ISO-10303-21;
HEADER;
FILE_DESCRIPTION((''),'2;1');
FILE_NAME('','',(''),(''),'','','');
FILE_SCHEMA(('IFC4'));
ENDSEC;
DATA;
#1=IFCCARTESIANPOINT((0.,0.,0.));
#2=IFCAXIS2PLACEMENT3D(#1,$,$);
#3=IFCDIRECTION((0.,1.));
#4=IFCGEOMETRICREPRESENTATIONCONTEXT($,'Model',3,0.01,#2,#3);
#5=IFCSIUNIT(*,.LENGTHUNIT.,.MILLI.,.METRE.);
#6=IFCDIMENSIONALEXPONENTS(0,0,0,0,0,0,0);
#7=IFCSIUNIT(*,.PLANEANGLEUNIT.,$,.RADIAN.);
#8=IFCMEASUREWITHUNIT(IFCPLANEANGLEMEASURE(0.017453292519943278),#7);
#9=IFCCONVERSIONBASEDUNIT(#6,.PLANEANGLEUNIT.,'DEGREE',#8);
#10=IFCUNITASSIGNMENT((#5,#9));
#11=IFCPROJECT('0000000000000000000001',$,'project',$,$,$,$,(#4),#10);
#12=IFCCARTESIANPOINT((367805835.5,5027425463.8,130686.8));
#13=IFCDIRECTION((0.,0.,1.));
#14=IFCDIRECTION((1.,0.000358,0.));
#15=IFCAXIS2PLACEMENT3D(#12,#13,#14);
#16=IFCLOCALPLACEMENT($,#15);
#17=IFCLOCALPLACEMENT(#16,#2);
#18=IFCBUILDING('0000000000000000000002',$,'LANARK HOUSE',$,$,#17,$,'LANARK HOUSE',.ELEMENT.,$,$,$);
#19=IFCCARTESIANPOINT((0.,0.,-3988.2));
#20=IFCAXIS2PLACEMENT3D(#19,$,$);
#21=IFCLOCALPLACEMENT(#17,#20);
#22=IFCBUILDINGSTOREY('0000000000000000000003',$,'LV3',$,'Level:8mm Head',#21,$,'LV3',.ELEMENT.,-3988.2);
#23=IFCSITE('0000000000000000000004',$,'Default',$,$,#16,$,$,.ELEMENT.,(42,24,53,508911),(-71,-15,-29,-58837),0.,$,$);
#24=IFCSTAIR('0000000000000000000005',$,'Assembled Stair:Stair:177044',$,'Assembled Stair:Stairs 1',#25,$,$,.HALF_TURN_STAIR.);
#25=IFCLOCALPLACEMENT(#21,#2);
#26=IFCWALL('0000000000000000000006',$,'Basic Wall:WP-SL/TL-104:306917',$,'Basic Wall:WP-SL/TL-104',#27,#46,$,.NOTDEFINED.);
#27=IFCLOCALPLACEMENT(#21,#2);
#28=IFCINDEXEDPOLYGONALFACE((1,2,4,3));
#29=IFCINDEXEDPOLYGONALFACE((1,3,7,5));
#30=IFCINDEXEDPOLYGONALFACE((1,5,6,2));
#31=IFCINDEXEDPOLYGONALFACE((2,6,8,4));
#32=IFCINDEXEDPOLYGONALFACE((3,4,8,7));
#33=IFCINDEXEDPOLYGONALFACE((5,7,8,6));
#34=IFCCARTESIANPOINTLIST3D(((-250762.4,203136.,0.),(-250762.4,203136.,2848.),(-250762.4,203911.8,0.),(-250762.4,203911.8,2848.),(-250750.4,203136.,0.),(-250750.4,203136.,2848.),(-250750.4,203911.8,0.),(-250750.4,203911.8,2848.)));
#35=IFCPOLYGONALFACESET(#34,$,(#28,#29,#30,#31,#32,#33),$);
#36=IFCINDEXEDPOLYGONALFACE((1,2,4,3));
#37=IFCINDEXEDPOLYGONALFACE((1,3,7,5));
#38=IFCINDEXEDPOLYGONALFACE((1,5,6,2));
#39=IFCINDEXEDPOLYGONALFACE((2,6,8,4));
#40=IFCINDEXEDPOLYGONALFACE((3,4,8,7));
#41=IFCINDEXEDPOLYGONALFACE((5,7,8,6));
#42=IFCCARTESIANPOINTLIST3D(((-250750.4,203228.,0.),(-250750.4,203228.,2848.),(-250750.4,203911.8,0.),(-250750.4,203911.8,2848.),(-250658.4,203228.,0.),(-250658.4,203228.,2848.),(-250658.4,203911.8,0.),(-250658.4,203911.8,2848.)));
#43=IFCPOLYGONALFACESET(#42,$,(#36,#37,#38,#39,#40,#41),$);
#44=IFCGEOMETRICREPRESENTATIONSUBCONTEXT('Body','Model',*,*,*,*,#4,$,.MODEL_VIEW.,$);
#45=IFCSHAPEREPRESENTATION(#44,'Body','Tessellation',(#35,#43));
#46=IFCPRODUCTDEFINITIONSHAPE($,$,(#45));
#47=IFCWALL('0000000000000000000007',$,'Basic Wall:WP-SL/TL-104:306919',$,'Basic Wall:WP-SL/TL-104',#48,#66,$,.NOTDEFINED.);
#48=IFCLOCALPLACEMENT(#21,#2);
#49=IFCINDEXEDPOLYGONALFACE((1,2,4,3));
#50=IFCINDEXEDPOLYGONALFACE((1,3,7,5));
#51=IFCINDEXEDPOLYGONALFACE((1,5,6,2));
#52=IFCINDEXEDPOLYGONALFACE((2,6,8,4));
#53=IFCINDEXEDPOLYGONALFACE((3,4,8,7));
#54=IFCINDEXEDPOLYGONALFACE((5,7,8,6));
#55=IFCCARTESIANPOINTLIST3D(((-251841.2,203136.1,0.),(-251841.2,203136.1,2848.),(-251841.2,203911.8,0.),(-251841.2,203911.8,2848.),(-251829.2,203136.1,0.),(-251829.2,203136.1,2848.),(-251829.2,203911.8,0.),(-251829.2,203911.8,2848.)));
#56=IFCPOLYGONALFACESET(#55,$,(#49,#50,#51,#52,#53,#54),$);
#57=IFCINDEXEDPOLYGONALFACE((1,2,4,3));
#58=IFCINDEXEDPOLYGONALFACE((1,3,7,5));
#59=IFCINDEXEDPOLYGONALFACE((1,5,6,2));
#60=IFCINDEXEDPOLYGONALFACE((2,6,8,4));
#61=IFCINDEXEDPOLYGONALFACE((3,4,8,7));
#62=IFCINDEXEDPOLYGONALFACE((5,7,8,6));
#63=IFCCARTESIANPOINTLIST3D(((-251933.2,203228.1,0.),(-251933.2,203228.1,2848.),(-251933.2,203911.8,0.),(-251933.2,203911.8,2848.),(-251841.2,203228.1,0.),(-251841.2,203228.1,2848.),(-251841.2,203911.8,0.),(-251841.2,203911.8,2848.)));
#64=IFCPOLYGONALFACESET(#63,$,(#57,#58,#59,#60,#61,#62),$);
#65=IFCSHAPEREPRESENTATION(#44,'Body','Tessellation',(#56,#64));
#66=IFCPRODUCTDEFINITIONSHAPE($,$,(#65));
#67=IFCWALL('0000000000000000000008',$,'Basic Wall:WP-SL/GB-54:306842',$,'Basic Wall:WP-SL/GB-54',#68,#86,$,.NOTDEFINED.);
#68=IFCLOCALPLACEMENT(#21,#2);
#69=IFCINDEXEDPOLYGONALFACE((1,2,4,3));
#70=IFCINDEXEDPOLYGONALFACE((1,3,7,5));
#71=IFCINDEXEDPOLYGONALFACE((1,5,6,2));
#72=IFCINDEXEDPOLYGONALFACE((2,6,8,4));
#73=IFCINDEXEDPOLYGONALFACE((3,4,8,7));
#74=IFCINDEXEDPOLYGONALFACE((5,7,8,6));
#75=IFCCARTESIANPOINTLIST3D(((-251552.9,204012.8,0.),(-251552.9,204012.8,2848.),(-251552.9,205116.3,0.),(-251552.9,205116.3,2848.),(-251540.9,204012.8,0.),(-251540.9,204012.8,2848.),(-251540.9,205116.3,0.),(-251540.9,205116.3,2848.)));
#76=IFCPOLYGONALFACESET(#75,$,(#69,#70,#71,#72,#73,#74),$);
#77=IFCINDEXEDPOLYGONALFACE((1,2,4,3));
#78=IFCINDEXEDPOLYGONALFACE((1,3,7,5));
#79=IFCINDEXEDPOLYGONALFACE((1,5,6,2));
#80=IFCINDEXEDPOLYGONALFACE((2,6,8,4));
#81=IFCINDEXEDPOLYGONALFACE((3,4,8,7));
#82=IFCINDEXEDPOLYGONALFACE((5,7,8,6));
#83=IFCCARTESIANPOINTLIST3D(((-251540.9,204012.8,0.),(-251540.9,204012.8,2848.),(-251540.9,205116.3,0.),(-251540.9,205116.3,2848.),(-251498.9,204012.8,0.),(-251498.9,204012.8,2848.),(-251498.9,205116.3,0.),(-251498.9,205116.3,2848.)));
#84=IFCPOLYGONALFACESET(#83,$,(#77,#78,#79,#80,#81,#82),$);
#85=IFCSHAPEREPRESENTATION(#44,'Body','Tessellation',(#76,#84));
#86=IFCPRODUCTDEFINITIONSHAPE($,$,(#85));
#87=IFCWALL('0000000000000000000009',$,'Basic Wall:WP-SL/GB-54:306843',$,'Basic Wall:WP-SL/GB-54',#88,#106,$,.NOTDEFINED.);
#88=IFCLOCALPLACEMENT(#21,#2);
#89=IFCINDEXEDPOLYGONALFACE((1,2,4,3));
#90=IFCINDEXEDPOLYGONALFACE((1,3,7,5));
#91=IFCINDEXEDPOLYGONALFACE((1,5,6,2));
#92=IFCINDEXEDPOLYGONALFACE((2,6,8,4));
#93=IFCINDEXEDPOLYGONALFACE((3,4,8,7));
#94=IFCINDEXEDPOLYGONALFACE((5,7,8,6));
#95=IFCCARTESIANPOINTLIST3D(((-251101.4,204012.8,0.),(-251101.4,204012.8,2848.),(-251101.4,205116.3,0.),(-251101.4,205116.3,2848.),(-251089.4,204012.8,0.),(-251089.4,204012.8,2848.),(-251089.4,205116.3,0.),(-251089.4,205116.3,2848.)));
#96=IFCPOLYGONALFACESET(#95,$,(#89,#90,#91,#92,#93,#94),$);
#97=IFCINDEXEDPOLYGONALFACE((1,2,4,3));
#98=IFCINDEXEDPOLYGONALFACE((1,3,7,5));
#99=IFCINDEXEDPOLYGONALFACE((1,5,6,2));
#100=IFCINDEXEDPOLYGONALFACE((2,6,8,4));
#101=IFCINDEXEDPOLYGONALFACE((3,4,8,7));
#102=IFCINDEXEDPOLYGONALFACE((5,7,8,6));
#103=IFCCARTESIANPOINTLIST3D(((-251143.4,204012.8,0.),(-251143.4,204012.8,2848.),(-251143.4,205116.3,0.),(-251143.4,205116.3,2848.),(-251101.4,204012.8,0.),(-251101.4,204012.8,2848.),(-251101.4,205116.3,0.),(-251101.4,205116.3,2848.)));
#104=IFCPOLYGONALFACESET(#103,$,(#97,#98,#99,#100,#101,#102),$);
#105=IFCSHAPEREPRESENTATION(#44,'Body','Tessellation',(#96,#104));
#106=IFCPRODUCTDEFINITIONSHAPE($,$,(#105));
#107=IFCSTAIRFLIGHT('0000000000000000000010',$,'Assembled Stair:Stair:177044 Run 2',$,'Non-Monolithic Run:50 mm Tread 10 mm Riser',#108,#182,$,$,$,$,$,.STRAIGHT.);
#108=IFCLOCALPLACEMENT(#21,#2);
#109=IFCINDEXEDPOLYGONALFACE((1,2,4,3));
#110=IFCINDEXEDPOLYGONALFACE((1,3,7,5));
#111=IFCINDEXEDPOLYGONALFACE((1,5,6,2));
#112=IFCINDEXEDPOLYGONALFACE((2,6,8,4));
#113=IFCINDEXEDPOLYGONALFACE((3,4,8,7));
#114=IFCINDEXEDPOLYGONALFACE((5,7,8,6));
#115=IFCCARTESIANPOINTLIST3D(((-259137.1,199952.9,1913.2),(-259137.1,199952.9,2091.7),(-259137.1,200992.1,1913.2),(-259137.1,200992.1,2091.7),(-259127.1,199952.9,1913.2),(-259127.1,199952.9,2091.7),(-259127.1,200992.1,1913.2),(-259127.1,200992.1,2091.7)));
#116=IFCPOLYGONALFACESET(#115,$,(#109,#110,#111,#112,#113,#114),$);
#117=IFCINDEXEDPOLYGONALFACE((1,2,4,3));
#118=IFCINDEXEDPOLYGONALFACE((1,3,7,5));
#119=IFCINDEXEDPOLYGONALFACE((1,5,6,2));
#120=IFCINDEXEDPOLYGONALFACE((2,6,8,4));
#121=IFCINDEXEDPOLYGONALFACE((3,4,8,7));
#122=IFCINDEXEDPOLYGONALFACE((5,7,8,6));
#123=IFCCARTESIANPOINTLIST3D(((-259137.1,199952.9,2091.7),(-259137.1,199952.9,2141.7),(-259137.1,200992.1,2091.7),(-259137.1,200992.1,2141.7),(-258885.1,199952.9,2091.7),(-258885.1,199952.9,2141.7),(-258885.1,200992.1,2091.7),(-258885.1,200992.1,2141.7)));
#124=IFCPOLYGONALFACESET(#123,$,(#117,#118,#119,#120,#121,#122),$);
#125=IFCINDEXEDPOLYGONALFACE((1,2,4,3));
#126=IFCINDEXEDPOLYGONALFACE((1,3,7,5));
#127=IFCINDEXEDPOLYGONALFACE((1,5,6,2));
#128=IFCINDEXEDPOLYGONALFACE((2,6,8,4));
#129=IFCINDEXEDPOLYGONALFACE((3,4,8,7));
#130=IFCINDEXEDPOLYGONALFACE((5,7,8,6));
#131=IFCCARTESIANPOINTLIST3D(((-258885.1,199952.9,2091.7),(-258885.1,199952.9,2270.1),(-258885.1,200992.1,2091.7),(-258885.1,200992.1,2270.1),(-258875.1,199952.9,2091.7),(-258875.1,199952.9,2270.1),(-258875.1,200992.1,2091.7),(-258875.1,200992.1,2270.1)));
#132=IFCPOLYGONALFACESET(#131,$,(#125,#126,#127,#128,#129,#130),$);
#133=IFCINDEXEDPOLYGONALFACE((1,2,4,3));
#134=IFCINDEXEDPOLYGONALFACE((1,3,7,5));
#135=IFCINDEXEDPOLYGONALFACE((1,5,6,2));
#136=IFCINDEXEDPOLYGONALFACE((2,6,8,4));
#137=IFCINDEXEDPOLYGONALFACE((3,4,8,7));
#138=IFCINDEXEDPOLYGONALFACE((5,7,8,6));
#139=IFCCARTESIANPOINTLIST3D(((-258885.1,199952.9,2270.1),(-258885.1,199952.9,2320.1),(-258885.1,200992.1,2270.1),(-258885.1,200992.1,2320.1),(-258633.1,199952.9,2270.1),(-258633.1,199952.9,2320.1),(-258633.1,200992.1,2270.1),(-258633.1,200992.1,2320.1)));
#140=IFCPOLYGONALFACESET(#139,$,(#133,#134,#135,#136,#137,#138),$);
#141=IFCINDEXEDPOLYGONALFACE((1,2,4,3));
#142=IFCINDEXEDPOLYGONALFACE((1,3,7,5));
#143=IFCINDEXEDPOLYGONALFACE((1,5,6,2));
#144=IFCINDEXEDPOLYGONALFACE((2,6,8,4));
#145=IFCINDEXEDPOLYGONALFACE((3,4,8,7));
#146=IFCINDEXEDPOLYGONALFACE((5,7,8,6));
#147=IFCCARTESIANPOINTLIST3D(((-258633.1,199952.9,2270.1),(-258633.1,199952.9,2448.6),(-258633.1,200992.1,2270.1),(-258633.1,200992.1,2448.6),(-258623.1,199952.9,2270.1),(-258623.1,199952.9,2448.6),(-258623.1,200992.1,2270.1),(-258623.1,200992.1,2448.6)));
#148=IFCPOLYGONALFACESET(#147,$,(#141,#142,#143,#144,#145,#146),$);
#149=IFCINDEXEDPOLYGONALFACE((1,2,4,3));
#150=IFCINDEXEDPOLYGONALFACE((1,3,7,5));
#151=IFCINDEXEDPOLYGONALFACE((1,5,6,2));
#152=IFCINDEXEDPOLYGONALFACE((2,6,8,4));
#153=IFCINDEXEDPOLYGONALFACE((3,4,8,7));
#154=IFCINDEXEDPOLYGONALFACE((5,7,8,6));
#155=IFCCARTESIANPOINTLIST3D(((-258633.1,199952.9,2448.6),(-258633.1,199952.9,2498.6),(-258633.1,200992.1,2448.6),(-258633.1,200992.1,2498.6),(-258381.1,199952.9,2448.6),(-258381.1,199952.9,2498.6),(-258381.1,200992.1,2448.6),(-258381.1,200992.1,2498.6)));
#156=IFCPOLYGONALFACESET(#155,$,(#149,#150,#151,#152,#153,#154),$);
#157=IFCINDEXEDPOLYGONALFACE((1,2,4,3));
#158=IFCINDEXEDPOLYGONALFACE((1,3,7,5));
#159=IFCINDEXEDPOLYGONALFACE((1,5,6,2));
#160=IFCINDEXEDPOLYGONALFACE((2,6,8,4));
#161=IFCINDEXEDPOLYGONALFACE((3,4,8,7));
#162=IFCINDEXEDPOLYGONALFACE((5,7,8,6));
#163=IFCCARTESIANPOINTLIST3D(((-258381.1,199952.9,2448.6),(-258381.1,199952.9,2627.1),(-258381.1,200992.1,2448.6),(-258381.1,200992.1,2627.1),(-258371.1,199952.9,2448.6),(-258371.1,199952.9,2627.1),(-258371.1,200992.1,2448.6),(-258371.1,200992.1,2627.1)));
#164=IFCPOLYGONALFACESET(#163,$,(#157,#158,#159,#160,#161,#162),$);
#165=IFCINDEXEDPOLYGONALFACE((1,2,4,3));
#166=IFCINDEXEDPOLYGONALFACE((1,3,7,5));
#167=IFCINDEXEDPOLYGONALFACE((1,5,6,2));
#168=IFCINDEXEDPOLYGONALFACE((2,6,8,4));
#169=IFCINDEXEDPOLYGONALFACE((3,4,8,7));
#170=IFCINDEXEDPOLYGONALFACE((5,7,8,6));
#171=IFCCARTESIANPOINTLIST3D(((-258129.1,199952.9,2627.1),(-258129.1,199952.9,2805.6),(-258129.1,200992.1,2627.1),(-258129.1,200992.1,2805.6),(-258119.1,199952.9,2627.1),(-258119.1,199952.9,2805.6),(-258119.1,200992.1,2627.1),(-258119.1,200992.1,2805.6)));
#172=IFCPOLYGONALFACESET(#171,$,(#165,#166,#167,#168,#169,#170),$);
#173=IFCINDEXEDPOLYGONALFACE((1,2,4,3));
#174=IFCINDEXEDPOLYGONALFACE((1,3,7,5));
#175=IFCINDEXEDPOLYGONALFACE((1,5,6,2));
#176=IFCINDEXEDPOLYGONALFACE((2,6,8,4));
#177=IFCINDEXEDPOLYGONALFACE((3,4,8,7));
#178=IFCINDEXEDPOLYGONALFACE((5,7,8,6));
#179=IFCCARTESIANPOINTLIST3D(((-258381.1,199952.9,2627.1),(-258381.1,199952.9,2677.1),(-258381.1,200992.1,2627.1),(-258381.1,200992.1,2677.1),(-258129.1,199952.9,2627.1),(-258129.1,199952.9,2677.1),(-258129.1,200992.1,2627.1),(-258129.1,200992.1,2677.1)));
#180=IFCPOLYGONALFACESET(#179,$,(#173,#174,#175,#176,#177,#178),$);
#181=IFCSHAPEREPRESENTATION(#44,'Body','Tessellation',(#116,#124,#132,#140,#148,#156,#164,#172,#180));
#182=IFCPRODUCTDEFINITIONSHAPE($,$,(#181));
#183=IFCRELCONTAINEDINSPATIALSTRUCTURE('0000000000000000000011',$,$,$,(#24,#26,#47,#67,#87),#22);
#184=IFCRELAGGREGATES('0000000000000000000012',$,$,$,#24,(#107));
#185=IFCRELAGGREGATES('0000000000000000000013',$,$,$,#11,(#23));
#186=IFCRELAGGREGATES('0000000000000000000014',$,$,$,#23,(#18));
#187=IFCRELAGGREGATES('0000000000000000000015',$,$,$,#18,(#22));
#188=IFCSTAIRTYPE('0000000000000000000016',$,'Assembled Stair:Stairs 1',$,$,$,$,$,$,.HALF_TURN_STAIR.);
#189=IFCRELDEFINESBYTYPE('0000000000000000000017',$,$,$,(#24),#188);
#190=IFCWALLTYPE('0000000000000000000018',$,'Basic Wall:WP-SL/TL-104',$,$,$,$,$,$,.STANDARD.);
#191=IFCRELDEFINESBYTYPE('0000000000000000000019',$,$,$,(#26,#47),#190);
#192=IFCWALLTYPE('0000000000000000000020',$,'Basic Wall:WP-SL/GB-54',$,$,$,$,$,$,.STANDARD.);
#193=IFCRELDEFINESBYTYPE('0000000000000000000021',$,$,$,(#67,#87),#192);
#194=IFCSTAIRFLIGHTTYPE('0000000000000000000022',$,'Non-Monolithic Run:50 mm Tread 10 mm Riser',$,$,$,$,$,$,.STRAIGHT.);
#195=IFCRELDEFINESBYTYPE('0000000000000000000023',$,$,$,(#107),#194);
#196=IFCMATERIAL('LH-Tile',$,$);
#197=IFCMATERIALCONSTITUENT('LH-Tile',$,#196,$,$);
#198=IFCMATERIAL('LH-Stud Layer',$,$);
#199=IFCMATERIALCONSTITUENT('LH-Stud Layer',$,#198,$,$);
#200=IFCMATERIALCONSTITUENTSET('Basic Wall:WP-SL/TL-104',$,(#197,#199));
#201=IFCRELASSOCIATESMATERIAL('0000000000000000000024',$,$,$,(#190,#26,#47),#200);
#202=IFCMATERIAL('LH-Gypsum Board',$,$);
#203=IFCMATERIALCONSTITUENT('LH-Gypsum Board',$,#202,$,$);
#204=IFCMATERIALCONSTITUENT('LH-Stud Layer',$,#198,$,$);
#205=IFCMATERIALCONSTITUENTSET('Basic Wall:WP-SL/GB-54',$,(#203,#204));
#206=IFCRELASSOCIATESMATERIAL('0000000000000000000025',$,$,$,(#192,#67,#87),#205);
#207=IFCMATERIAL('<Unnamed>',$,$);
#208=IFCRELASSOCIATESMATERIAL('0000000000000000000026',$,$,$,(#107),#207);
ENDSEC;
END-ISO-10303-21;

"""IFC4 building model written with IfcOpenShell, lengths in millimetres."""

from ifc_helpers import new_model, entity, si_unit, converted_unit, direction, frame, origin, place, context, subcontext, project, spatial, indexed_curve, outline, extrude, material, constituent, constituent_set, type_object, element, aggregate, save


model = new_model("IFC4")

# Units and contexts
model_context = context("Model", 3, precision=0.01, world=origin(), true_north=direction((0.0, 1.0)))
body_context = subcontext(model_context, "Body", "Model", "MODEL_VIEW")
ifc_project = project(units=[si_unit("LENGTHUNIT", "METRE", prefix="MILLI"), converted_unit("PLANEANGLEUNIT", "DEGREE", entity("IfcPlaneAngleMeasure", 0.017453292519943278), si_unit("PLANEANGLEUNIT", "RADIAN"), dimensions=[0, 0, 0, 0, 0, 0, 0])], contexts=[model_context])

# Site, building, storey
site_placement = place(None, frame((367805835.5, 5027425463.8, 130686.8), z_axis=(0.0, 0.0, 1.0), x_axis=(1.0, 0.000358, 0.0)))
site = spatial("IfcSite", under=ifc_project, at=site_placement, Name="Default", CompositionType="ELEMENT", RefLatitude=(42, 24, 53, 508911), RefLongitude=(-71, -15, -29, -58837), RefElevation=0.0)
building_placement = place(site_placement, origin())
building = spatial("IfcBuilding", under=site, at=building_placement, Name="LANARK HOUSE", LongName="LANARK HOUSE", CompositionType="ELEMENT")
storey_placement = place(building_placement, frame((0.0, 0.0, -3988.2)))
storey = spatial("IfcBuildingStorey", under=building, at=storey_placement, Name="LV3", ObjectType="Level:8mm Head", LongName="LV3", CompositionType="ELEMENT", Elevation=-3988.2)

# Stair
stair_type = type_object("IfcStairType", Name="Assembled Stair:Stairs 1", PredefinedType="HALF_TURN_STAIR")
stair_placement = place(storey_placement, origin())
stair = element("IfcStair", 1, at=stair_placement, inside=storey, type_object=stair_type, Name="Assembled Stair:Stair:177044", ObjectType="Assembled Stair:Stairs 1", PredefinedType="HALF_TURN_STAIR")
ifc_material_1 = material(Name="<Unnamed>")

# Walls
ifc_material_2 = material(Name="LH-Tile")
ifc_constituent_1 = constituent(ifc_material_2, Name="LH-Tile")
ifc_material_3 = material(Name="LH-Stud Layer")
ifc_constituent_2 = constituent(ifc_material_3, Name="LH-Stud Layer")
ifc_constituent_set_1 = constituent_set(constituents=[ifc_constituent_1, ifc_constituent_2], Name="Basic Wall:WP-SL/TL-104")
wall_type_1 = type_object("IfcWallType", Name="Basic Wall:WP-SL/TL-104", PredefinedType="STANDARD", material=ifc_constituent_set_1)
wall_1_placement = place(storey_placement, frame((-250710.4, 203228.0, 0.0), z_axis=(0.0, 0.0, 1.0), x_axis=(0.0, 1.0, 0.0)))
element("IfcWall", 2, at=wall_1_placement, inside=storey, type_object=wall_type_1, material=ifc_constituent_set_1, Name="Basic Wall:WP-SL/TL-104:306917", ObjectType="Basic Wall:WP-SL/TL-104", PredefinedType="NOTDEFINED", context=body_context, shape_type="SweptSolid", body=[
    extrude(outline(indexed_curve([(-6.0, -387.9), (6.0, -387.9), (6.0, 387.9), (-6.0, 387.9), (-6.0, -387.9)], self_intersect=False)), frame((295.9, 46.0, 0.0), z_axis=(0.0, 0.0, 1.0), x_axis=(0.0, -1.0, 0.0)), (0.0, 0.0, 1.0), 2848.0),
    extrude(outline(indexed_curve([(-46.0, -341.9), (46.0, -341.9), (46.0, 341.9), (-46.0, 341.9), (-46.0, -341.9)], self_intersect=False)), frame((341.9, -6.0, 0.0), z_axis=(0.0, 0.0, 1.0), x_axis=(0.0, 1.0, 0.0)), (0.0, 0.0, 1.0), 2848.0),
])
wall_2_placement = place(storey_placement, frame((-251881.2, 203911.8, 0.0), z_axis=(0.0, 0.0, 1.0), x_axis=(0.0, -1.0, 0.0)))
element("IfcWall", 3, at=wall_2_placement, inside=storey, type_object=wall_type_1, material=ifc_constituent_set_1, Name="Basic Wall:WP-SL/TL-104:306919", ObjectType="Basic Wall:WP-SL/TL-104", PredefinedType="NOTDEFINED", context=body_context, shape_type="SweptSolid", body=[
    extrude(outline(indexed_curve([(-6.0, -387.8), (6.0, -387.8), (6.0, 387.8), (-6.0, 387.8), (-6.0, -387.8)], self_intersect=False)), frame((387.8, 46.0, 0.0), z_axis=(0.0, 0.0, 1.0), x_axis=(0.0, -1.0, 0.0)), (0.0, 0.0, 1.0), 2848.0),
    extrude(outline(indexed_curve([(-46.0, -341.8), (46.0, -341.8), (46.0, 341.8), (-46.0, 341.8), (-46.0, -341.8)], self_intersect=False)), frame((341.8, -6.0, 0.0), z_axis=(0.0, 0.0, 1.0), x_axis=(0.0, 1.0, 0.0)), (0.0, 0.0, 1.0), 2848.0),
])
ifc_material_4 = material(Name="LH-Gypsum Board")
ifc_constituent_3 = constituent(ifc_material_4, Name="LH-Gypsum Board")
ifc_constituent_4 = constituent(ifc_material_3, Name="LH-Stud Layer")
ifc_constituent_set_2 = constituent_set(constituents=[ifc_constituent_3, ifc_constituent_4], Name="Basic Wall:WP-SL/GB-54")
wall_type_2 = type_object("IfcWallType", Name="Basic Wall:WP-SL/GB-54", PredefinedType="STANDARD", material=ifc_constituent_set_2)
wall_3_placement = place(storey_placement, frame((-251525.9, 204012.8, 0.0), z_axis=(0.0, 0.0, 1.0), x_axis=(0.0, 1.0, 0.0)))
element("IfcWall", 4, at=wall_3_placement, inside=storey, type_object=wall_type_2, material=ifc_constituent_set_2, Name="Basic Wall:WP-SL/GB-54:306842", ObjectType="Basic Wall:WP-SL/GB-54", PredefinedType="NOTDEFINED", context=body_context, shape_type="SweptSolid", body=[
    extrude(outline(indexed_curve([(-6.0, -551.8), (6.0, -551.8), (6.0, 551.8), (-6.0, 551.8), (-6.0, -551.8)], self_intersect=False)), frame((551.8, 21.0, 0.0), z_axis=(0.0, 0.0, 1.0), x_axis=(0.0, -1.0, 0.0)), (0.0, 0.0, 1.0), 2848.0),
    extrude(outline(indexed_curve([(-21.0, -551.8), (21.0, -551.8), (21.0, 551.8), (-21.0, 551.8), (-21.0, -551.8)], self_intersect=False)), frame((551.8, -6.0, 0.0), z_axis=(0.0, 0.0, 1.0), x_axis=(0.0, 1.0, 0.0)), (0.0, 0.0, 1.0), 2848.0),
])
wall_4_placement = place(storey_placement, frame((-251116.4, 205116.3, 0.0), z_axis=(0.0, 0.0, 1.0), x_axis=(0.0, -1.0, 0.0)))
element("IfcWall", 5, at=wall_4_placement, inside=storey, type_object=wall_type_2, material=ifc_constituent_set_2, Name="Basic Wall:WP-SL/GB-54:306843", ObjectType="Basic Wall:WP-SL/GB-54", PredefinedType="NOTDEFINED", context=body_context, shape_type="SweptSolid", body=[
    extrude(outline(indexed_curve([(-6.0, -551.8), (6.0, -551.8), (6.0, 551.8), (-6.0, 551.8), (-6.0, -551.8)], self_intersect=False)), frame((551.8, 21.0, 0.0), z_axis=(0.0, 0.0, 1.0), x_axis=(0.0, -1.0, 0.0)), (0.0, 0.0, 1.0), 2848.0),
    extrude(outline(indexed_curve([(-21.0, -551.8), (21.0, -551.8), (21.0, 551.8), (-21.0, 551.8), (-21.0, -551.8)], self_intersect=False)), frame((551.8, -6.0, 0.0), z_axis=(0.0, 0.0, 1.0), x_axis=(0.0, 1.0, 0.0)), (0.0, 0.0, 1.0), 2848.0),
])

# Stair flight
stair_flight_type = type_object("IfcStairFlightType", Name="Non-Monolithic Run:50 mm Tread 10 mm Riser", PredefinedType="STRAIGHT")
stair_flight_placement = place(stair_placement, frame((-259137.1, 199952.9, 0.0)))
stair_flight = element("IfcStairFlight", 6, at=stair_flight_placement, type_object=stair_flight_type, material=ifc_material_1, Name="Assembled Stair:Stair:177044 Run 2", ObjectType="Non-Monolithic Run:50 mm Tread 10 mm Riser", PredefinedType="STRAIGHT", context=body_context, shape_type="SweptSolid", body=[
    extrude(outline(indexed_curve([(-519.6, -5.0), (519.6, -5.0), (519.6, 5.0), (-519.6, 5.0), (-519.6, -5.0)], self_intersect=False)), frame((5.0, 519.6, 1913.2), z_axis=(0.0, 0.0, 1.0), x_axis=(0.0, 1.0, 0.0)), (0.0, 0.0, 1.0), 178.5),
    extrude(outline(indexed_curve([(-126.0, -519.6), (126.0, -519.6), (126.0, 519.6), (-126.0, 519.6), (-126.0, -519.6)], self_intersect=False)), frame((126.0, 519.6, 2091.7), z_axis=(0.0, 0.0, 1.0), x_axis=(-1.0, 0.0, 0.0)), (0.0, 0.0, 1.0), 50.0),
    extrude(outline(indexed_curve([(-519.6, -5.0), (519.6, -5.0), (519.6, 5.0), (-519.6, 5.0), (-519.6, -5.0)], self_intersect=False)), frame((257.0, 519.6, 2091.7), z_axis=(0.0, 0.0, 1.0), x_axis=(0.0, 1.0, 0.0)), (0.0, 0.0, 1.0), 178.5),
    extrude(outline(indexed_curve([(-126.0, -519.6), (126.0, -519.6), (126.0, 519.6), (-126.0, 519.6), (-126.0, -519.6)], self_intersect=False)), frame((378.0, 519.6, 2270.1), z_axis=(0.0, 0.0, 1.0), x_axis=(-1.0, 0.0, 0.0)), (0.0, 0.0, 1.0), 50.0),
    extrude(outline(indexed_curve([(-519.6, -5.0), (519.6, -5.0), (519.6, 5.0), (-519.6, 5.0), (-519.6, -5.0)], self_intersect=False)), frame((509.0, 519.6, 2270.1), z_axis=(0.0, 0.0, 1.0), x_axis=(0.0, 1.0, 0.0)), (0.0, 0.0, 1.0), 178.5),
    extrude(outline(indexed_curve([(-126.0, -519.6), (126.0, -519.6), (126.0, 519.6), (-126.0, 519.6), (-126.0, -519.6)], self_intersect=False)), frame((630.0, 519.6, 2448.6), z_axis=(0.0, 0.0, 1.0), x_axis=(-1.0, 0.0, 0.0)), (0.0, 0.0, 1.0), 50.0),
    extrude(outline(indexed_curve([(-519.6, -5.0), (519.6, -5.0), (519.6, 5.0), (-519.6, 5.0), (-519.6, -5.0)], self_intersect=False)), frame((761.0, 519.6, 2448.6), z_axis=(0.0, 0.0, 1.0), x_axis=(0.0, 1.0, 0.0)), (0.0, 0.0, 1.0), 178.5),
    extrude(outline(indexed_curve([(-519.6, -5.0), (519.6, -5.0), (519.6, 5.0), (-519.6, 5.0), (-519.6, -5.0)], self_intersect=False)), frame((1013.0, 519.6, 2627.1), z_axis=(0.0, 0.0, 1.0), x_axis=(0.0, 1.0, 0.0)), (0.0, 0.0, 1.0), 178.5),
    extrude(outline(indexed_curve([(-126.0, -519.6), (126.0, -519.6), (126.0, 519.6), (-126.0, 519.6), (-126.0, -519.6)], self_intersect=False)), frame((882.0, 519.6, 2627.1), z_axis=(0.0, 0.0, 1.0), x_axis=(-1.0, 0.0, 0.0)), (0.0, 0.0, 1.0), 50.0),
])
aggregate(stair, [stair_flight])

save(model, "model.ifc")
